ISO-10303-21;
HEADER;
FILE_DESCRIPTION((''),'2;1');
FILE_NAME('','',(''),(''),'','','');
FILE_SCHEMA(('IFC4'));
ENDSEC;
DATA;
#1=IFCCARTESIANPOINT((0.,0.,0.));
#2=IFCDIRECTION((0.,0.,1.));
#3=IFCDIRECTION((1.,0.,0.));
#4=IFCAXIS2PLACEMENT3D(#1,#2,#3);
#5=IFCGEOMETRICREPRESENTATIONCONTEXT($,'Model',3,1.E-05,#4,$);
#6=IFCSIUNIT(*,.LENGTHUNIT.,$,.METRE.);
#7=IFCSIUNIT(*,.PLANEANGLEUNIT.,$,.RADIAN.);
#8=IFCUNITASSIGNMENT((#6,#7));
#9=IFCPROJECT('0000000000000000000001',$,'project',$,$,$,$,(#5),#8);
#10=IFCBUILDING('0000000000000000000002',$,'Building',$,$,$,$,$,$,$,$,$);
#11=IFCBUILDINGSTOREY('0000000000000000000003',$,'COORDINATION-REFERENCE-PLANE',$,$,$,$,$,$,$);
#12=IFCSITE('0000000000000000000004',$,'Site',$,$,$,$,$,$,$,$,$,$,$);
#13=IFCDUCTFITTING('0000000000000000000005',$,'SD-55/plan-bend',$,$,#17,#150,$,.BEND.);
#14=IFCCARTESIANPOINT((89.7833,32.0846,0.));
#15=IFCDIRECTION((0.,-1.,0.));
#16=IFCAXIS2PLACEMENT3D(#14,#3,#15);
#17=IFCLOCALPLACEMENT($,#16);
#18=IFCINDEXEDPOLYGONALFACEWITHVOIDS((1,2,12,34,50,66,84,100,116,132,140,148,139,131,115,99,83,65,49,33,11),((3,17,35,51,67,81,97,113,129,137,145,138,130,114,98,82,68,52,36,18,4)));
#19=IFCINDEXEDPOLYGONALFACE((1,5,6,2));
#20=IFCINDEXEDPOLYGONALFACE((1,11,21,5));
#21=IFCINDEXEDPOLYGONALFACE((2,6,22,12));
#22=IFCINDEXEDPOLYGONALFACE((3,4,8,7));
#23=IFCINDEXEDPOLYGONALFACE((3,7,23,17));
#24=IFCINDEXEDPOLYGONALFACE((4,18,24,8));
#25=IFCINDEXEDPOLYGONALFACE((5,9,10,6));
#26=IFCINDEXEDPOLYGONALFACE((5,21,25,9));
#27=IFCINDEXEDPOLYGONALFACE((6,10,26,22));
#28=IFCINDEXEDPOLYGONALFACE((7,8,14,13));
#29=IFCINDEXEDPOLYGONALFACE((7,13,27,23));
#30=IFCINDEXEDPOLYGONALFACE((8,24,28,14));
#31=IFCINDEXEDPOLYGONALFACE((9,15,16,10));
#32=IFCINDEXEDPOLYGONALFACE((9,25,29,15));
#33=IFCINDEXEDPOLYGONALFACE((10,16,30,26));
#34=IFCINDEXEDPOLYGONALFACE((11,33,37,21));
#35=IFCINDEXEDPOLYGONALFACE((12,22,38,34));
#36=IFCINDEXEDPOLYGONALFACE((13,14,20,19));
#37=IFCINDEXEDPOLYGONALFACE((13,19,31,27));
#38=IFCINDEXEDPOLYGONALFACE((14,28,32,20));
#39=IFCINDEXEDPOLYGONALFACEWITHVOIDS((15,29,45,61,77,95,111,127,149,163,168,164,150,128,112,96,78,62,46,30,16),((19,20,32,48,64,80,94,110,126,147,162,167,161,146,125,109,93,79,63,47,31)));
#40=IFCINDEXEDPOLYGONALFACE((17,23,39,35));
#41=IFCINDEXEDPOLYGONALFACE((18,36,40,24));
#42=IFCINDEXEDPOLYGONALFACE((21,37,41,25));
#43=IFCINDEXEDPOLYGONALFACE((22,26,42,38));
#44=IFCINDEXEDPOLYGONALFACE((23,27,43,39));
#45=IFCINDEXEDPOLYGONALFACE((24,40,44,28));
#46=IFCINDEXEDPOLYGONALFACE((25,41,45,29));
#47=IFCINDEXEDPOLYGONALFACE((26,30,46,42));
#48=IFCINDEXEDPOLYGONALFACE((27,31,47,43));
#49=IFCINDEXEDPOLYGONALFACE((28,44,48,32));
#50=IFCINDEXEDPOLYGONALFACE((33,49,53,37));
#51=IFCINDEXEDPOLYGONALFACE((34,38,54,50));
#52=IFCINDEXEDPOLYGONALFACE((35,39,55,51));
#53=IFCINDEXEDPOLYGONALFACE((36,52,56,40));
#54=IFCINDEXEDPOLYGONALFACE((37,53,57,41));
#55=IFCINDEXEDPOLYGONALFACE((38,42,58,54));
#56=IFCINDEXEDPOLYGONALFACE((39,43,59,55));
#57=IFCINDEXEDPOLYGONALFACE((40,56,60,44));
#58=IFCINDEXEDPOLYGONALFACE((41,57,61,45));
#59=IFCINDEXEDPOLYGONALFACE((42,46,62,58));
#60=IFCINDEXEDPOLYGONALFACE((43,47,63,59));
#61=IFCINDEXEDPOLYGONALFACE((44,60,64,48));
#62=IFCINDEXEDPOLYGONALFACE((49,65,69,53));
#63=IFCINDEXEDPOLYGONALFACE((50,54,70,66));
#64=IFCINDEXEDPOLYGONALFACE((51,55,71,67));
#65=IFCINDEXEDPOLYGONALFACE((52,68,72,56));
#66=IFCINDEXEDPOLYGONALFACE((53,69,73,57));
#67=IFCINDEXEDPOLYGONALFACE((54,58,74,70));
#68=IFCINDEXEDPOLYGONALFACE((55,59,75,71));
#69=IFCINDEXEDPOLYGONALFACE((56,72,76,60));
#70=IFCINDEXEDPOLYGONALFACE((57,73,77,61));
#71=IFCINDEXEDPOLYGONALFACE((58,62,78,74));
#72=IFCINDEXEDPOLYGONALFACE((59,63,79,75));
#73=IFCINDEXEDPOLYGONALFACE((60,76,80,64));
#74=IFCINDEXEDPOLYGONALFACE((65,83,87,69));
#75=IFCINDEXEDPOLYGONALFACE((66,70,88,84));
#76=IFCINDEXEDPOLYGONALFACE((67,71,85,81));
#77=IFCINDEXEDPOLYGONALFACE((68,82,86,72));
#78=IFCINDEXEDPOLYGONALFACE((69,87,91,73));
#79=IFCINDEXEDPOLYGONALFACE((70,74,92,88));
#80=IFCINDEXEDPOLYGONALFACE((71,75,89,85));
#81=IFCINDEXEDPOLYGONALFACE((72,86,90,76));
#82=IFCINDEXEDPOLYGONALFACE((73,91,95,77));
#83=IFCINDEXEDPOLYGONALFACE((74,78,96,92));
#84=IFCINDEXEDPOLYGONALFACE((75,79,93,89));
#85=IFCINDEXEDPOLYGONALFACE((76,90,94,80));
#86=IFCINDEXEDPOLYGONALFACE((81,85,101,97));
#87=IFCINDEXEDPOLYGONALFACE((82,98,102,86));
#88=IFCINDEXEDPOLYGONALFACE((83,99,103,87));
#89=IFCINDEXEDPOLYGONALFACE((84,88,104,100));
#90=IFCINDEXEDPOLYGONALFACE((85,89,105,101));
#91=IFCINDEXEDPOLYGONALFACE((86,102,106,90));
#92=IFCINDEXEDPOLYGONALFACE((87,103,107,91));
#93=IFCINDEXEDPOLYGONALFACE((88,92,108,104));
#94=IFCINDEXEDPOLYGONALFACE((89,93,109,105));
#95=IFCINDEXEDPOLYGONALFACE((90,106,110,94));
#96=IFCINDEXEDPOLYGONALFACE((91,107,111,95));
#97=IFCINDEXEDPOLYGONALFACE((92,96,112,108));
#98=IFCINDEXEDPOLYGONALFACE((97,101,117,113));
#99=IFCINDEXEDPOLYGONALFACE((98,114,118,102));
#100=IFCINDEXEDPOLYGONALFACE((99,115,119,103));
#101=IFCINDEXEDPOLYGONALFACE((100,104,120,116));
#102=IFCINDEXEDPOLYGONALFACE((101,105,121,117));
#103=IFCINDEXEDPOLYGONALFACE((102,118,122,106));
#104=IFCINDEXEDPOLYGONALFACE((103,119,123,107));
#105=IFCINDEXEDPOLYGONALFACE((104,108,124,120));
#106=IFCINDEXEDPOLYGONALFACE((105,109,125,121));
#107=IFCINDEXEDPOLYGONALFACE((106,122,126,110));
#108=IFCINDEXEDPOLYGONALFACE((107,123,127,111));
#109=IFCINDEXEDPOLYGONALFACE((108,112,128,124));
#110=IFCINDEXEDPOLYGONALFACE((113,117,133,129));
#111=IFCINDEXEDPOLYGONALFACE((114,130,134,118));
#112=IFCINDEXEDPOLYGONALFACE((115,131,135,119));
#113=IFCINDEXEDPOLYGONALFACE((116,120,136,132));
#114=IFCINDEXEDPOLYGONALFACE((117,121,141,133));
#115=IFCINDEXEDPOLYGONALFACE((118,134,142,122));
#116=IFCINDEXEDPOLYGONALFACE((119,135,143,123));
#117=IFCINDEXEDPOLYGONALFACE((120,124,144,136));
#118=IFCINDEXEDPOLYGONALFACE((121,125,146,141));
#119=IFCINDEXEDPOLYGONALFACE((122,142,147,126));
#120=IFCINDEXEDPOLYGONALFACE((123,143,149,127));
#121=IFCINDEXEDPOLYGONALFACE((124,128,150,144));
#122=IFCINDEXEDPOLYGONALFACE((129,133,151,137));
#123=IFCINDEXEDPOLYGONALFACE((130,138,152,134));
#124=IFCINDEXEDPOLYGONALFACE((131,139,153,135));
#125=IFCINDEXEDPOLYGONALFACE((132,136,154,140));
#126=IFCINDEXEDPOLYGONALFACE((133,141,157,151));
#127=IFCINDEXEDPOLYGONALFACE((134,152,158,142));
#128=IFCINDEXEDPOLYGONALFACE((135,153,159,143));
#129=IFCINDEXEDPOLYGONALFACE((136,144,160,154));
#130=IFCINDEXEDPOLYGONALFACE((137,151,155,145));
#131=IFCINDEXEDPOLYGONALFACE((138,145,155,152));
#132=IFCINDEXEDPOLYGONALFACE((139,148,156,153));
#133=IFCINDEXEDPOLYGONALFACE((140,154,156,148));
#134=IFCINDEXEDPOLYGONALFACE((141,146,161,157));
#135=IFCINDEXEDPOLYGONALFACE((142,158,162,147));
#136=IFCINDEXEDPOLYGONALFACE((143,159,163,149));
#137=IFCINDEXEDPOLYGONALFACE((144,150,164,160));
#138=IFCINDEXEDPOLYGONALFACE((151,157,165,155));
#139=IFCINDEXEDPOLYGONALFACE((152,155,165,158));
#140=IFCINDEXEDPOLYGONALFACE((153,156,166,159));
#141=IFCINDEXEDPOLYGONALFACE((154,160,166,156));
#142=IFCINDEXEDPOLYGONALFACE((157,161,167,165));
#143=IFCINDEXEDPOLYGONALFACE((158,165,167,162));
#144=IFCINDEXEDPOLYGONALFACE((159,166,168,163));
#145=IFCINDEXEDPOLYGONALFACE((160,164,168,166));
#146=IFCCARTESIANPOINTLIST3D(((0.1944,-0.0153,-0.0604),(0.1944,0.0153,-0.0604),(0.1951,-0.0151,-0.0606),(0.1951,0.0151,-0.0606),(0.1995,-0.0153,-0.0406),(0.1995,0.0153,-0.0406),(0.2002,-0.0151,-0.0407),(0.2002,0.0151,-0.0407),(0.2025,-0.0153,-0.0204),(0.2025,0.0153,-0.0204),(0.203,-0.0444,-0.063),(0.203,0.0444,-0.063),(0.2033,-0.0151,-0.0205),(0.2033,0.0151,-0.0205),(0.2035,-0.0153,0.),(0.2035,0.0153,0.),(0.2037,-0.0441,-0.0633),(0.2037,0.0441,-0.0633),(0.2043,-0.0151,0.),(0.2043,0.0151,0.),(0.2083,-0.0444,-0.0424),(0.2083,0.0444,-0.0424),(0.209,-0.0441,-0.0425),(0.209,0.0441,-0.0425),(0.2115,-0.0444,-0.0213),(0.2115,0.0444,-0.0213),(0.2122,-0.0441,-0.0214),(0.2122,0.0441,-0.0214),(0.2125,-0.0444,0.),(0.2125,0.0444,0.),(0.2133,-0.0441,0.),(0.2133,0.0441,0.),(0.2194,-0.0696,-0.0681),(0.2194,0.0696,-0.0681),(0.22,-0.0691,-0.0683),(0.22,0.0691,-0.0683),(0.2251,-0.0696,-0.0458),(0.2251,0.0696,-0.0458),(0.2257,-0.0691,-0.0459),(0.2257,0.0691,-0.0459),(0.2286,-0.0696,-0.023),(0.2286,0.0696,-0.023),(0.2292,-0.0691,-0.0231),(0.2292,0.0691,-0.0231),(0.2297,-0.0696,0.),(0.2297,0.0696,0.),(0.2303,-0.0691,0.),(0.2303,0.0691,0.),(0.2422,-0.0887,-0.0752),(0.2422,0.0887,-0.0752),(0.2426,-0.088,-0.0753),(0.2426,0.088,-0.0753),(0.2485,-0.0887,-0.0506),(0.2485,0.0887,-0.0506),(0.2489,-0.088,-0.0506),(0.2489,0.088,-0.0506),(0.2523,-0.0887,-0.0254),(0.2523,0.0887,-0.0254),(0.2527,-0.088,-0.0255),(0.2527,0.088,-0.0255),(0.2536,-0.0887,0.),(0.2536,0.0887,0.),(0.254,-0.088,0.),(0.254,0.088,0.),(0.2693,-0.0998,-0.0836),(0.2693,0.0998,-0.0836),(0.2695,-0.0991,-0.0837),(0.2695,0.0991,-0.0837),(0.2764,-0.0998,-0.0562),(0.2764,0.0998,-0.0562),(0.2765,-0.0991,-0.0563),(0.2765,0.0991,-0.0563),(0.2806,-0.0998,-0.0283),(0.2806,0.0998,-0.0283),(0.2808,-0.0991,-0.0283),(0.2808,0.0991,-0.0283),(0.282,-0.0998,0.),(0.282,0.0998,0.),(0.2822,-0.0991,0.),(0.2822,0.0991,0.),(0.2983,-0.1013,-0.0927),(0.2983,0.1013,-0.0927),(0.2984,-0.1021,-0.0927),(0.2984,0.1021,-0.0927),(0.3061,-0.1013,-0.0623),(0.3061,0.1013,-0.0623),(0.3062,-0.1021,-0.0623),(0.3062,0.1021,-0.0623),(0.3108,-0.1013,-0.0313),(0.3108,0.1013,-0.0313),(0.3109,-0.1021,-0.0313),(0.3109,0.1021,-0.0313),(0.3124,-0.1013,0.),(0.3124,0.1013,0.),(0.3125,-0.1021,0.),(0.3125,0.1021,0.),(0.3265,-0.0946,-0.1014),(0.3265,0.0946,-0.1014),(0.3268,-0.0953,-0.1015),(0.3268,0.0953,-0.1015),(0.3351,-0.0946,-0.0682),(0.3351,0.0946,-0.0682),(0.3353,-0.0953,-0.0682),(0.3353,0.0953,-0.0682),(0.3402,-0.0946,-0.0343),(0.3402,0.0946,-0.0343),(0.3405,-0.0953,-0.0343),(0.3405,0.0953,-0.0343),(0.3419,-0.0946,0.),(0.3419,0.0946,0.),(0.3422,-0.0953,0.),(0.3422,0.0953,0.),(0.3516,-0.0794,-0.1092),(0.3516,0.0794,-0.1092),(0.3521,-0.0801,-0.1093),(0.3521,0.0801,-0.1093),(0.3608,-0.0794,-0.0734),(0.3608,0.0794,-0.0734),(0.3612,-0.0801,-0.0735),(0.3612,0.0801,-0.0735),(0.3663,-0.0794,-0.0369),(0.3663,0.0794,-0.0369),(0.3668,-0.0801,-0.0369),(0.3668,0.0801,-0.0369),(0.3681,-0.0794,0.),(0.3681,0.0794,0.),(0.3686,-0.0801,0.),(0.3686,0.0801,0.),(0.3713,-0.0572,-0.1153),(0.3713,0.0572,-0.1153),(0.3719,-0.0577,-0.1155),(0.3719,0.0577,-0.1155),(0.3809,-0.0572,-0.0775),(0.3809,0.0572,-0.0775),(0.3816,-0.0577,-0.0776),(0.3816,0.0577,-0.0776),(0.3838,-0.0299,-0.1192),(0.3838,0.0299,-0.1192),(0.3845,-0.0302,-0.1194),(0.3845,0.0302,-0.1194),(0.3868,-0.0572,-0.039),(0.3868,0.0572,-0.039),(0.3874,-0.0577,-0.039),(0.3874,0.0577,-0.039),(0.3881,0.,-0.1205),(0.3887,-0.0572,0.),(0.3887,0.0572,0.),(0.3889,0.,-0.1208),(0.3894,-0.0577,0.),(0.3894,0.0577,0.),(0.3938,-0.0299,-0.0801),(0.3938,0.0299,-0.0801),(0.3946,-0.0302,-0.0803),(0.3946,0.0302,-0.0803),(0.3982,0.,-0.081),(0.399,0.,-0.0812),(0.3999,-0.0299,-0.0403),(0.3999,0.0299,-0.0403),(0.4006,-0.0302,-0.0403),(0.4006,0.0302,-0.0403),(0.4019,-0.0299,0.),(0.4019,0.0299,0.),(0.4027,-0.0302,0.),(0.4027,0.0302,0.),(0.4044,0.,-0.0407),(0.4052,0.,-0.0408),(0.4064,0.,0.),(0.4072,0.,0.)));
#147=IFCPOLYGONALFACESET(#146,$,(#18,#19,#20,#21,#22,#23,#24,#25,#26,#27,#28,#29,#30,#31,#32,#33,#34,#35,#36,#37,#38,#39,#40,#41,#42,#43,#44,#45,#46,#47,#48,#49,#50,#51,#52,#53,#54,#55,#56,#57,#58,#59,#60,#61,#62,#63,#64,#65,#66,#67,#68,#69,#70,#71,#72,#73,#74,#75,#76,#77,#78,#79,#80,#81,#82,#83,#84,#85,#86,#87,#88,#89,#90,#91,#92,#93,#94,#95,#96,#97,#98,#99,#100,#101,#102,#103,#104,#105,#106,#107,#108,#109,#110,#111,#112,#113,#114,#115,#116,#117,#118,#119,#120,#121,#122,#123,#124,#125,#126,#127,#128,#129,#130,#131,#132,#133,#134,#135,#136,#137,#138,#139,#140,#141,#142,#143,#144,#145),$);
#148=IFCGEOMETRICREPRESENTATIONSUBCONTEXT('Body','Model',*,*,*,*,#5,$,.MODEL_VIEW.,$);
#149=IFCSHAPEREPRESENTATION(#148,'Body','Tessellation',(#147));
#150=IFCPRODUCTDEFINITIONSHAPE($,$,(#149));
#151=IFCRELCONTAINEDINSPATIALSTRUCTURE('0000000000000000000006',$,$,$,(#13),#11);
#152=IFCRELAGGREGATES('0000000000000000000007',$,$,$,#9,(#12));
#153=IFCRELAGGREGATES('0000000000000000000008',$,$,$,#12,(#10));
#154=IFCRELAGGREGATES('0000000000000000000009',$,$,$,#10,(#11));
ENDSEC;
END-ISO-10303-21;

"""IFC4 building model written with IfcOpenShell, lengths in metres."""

from ifc_helpers import new_model, entity, si_unit, frame, origin_with_axes, place, context, subcontext, project, spatial, element, save


model = new_model("IFC4")

# Units and contexts
model_context = context("Model", 3, precision=1e-05, world=origin_with_axes())
body_context_1 = subcontext(model_context, "Body", "Model", "MODEL_VIEW")
ifc_project = project(units=[si_unit("LENGTHUNIT", "METRE"), si_unit("PLANEANGLEUNIT", "RADIAN")], contexts=[model_context])

# Site, building, storey
site = spatial("IfcSite", under=ifc_project, Name="Site")
building = spatial("IfcBuilding", under=site, Name="Building")
storey = spatial("IfcBuildingStorey", under=building, Name="COORDINATION-REFERENCE-PLANE")

# Duct fitting
duct_fitting_1_placement = place(None, frame((89.7833, 32.0846, 0.0), z_axis=(1.0, 0.0, 0.0), x_axis=(0.0, -1.0, 0.0)))
element("IfcDuctFitting", 1, at=duct_fitting_1_placement, inside=storey, Name="SD-55/plan-bend", PredefinedType="BEND", context=body_context_1, shape_type="SweptSolid", body=[
    entity("IfcRevolvedAreaSolid", entity("IfcCircleHollowProfileDef", "AREA", None, entity("IfcAxis2Placement2D", entity("IfcCartesianPoint", [0.3048, 0.0])), 0.1024, 0.0008), entity("IfcAxis2Placement3D", entity("IfcCartesianPoint", [0.0, 0.0, 0.0]), entity("IfcDirection", [0.0, 0.0, 1.0]), entity("IfcDirection", [1.0, 0.0, 0.0])), entity("IfcAxis1Placement", entity("IfcCartesianPoint", [0.0, 0.0, 0.0]), entity("IfcDirection", [0.0, 1.0, 0.0])), 0.301119),
])

save(model, "model.ifc")
